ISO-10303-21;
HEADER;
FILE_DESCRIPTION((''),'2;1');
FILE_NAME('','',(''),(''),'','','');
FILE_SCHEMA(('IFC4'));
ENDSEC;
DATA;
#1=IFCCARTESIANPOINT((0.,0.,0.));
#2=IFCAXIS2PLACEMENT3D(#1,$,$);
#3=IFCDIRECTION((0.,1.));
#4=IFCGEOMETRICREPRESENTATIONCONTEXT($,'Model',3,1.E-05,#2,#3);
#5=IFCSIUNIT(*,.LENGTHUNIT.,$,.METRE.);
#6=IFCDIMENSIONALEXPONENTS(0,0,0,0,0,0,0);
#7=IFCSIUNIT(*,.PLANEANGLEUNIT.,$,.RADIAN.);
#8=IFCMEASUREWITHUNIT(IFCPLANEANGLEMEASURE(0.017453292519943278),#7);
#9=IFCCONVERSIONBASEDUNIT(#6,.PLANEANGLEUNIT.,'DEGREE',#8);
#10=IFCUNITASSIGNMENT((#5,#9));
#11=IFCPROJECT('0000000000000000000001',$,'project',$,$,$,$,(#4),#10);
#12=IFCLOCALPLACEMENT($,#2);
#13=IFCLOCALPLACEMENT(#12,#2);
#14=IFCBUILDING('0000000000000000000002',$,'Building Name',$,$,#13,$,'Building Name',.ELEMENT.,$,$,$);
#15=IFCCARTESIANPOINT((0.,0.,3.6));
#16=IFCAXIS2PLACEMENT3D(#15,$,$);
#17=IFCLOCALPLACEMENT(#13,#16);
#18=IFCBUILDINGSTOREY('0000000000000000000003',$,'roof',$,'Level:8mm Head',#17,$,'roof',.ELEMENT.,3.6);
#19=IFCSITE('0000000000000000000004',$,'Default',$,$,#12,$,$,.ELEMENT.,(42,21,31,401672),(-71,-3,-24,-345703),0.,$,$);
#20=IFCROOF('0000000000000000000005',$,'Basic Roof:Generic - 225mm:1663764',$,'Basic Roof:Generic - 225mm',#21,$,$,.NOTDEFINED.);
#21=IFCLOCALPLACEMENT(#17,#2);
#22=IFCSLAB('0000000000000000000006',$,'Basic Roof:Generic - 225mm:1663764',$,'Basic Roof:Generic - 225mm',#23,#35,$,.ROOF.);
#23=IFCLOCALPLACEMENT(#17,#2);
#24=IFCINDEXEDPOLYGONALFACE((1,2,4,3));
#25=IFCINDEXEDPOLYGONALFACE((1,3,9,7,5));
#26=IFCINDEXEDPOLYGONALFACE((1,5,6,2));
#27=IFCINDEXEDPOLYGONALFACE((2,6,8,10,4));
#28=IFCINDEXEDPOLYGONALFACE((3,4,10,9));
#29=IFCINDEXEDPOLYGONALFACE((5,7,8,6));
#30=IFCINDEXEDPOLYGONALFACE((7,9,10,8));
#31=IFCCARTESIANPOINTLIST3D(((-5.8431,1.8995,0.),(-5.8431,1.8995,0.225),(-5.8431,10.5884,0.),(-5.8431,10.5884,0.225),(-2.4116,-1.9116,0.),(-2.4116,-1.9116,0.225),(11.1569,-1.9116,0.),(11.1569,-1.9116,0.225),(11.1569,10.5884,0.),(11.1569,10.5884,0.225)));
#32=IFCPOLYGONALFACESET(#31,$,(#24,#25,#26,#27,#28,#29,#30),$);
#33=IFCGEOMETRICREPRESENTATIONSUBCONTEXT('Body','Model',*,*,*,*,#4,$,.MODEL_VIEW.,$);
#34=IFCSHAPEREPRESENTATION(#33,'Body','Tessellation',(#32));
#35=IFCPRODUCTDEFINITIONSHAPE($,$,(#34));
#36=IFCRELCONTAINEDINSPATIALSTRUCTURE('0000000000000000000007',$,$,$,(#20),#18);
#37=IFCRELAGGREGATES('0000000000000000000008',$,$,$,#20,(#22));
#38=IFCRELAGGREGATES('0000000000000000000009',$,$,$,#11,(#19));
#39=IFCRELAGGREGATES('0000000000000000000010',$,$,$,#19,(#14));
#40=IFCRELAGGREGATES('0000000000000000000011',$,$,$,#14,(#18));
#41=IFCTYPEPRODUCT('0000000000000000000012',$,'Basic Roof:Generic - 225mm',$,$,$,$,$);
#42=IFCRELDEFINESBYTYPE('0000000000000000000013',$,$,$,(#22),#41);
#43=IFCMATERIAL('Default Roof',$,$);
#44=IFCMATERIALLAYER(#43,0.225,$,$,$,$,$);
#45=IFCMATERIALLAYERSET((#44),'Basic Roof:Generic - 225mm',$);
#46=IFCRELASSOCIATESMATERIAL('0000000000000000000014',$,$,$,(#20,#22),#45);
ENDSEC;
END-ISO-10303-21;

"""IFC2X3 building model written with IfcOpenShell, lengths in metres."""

from ifc_helpers import new_model, entity, si_unit, converted_unit, direction, frame, origin, place, context, subcontext, project, spatial, polyline, outline, extrude, material, layer, layer_set, type_object, element, aggregate, save


model = new_model("IFC2X3")

# Units and contexts
model_context = context("Model", 3, precision=1e-05, world=origin(), true_north=direction((0.0, 1.0)))
body_context = subcontext(model_context, "Body", "Model", "MODEL_VIEW")
ifc_project = project(units=[si_unit("LENGTHUNIT", "METRE"), converted_unit("PLANEANGLEUNIT", "DEGREE", entity("IfcPlaneAngleMeasure", 0.017453292519943278), si_unit("PLANEANGLEUNIT", "RADIAN"), dimensions=[0, 0, 0, 0, 0, 0, 0])], contexts=[model_context])

# Site, building, storey
site_placement = place(None, origin())
site = spatial("IfcSite", under=ifc_project, at=site_placement, Name="Default", CompositionType="ELEMENT", RefLatitude=(42, 21, 31, 401672), RefLongitude=(-71, -3, -24, -345703), RefElevation=0.0)
building_placement = place(site_placement, origin())
building = spatial("IfcBuilding", under=site, at=building_placement, Name="Building Name", LongName="Building Name", CompositionType="ELEMENT")
storey_placement = place(building_placement, frame((0.0, 0.0, 3.6)))
storey = spatial("IfcBuildingStorey", under=building, at=storey_placement, Name="roof", ObjectType="Level:8mm Head", LongName="roof", CompositionType="ELEMENT", Elevation=3.6)

# Roof, slab
ifc_material = material(Name="Default Roof")
ifc_layer = layer(ifc_material, 0.225)
ifc_layer_set = layer_set([ifc_layer], Name="Basic Roof:Generic - 225mm")
roof_placement = place(storey_placement, frame((-5.8431, -1.9116, 0.0)))
roof = element("IfcRoof", 1, at=roof_placement, inside=storey, material=ifc_layer_set, Name="Basic Roof:Generic - 225mm:1663764", ObjectType="Basic Roof:Generic - 225mm", ShapeType="NOTDEFINED")
type_product = type_object("IfcTypeProduct", Name="Basic Roof:Generic - 225mm")
slab_placement = place(roof_placement, origin())
slab = element("IfcSlab", 2, at=slab_placement, type_object=type_product, material=ifc_layer_set, Name="Basic Roof:Generic - 225mm:1663764", ObjectType="Basic Roof:Generic - 225mm", PredefinedType="ROOF", context=body_context, shape_type="SweptSolid", body=[
    extrude(outline(polyline([(8.5, 6.25), (-8.5, 6.25), (-8.5, -2.4389), (-5.0685, -6.25), (8.5, -6.25), (8.5, 6.25)])), frame((8.5, 6.25, 0.0)), (0.0, 0.0, 1.0), 0.225),
])
aggregate(roof, [slab])

save(model, "model.ifc")
